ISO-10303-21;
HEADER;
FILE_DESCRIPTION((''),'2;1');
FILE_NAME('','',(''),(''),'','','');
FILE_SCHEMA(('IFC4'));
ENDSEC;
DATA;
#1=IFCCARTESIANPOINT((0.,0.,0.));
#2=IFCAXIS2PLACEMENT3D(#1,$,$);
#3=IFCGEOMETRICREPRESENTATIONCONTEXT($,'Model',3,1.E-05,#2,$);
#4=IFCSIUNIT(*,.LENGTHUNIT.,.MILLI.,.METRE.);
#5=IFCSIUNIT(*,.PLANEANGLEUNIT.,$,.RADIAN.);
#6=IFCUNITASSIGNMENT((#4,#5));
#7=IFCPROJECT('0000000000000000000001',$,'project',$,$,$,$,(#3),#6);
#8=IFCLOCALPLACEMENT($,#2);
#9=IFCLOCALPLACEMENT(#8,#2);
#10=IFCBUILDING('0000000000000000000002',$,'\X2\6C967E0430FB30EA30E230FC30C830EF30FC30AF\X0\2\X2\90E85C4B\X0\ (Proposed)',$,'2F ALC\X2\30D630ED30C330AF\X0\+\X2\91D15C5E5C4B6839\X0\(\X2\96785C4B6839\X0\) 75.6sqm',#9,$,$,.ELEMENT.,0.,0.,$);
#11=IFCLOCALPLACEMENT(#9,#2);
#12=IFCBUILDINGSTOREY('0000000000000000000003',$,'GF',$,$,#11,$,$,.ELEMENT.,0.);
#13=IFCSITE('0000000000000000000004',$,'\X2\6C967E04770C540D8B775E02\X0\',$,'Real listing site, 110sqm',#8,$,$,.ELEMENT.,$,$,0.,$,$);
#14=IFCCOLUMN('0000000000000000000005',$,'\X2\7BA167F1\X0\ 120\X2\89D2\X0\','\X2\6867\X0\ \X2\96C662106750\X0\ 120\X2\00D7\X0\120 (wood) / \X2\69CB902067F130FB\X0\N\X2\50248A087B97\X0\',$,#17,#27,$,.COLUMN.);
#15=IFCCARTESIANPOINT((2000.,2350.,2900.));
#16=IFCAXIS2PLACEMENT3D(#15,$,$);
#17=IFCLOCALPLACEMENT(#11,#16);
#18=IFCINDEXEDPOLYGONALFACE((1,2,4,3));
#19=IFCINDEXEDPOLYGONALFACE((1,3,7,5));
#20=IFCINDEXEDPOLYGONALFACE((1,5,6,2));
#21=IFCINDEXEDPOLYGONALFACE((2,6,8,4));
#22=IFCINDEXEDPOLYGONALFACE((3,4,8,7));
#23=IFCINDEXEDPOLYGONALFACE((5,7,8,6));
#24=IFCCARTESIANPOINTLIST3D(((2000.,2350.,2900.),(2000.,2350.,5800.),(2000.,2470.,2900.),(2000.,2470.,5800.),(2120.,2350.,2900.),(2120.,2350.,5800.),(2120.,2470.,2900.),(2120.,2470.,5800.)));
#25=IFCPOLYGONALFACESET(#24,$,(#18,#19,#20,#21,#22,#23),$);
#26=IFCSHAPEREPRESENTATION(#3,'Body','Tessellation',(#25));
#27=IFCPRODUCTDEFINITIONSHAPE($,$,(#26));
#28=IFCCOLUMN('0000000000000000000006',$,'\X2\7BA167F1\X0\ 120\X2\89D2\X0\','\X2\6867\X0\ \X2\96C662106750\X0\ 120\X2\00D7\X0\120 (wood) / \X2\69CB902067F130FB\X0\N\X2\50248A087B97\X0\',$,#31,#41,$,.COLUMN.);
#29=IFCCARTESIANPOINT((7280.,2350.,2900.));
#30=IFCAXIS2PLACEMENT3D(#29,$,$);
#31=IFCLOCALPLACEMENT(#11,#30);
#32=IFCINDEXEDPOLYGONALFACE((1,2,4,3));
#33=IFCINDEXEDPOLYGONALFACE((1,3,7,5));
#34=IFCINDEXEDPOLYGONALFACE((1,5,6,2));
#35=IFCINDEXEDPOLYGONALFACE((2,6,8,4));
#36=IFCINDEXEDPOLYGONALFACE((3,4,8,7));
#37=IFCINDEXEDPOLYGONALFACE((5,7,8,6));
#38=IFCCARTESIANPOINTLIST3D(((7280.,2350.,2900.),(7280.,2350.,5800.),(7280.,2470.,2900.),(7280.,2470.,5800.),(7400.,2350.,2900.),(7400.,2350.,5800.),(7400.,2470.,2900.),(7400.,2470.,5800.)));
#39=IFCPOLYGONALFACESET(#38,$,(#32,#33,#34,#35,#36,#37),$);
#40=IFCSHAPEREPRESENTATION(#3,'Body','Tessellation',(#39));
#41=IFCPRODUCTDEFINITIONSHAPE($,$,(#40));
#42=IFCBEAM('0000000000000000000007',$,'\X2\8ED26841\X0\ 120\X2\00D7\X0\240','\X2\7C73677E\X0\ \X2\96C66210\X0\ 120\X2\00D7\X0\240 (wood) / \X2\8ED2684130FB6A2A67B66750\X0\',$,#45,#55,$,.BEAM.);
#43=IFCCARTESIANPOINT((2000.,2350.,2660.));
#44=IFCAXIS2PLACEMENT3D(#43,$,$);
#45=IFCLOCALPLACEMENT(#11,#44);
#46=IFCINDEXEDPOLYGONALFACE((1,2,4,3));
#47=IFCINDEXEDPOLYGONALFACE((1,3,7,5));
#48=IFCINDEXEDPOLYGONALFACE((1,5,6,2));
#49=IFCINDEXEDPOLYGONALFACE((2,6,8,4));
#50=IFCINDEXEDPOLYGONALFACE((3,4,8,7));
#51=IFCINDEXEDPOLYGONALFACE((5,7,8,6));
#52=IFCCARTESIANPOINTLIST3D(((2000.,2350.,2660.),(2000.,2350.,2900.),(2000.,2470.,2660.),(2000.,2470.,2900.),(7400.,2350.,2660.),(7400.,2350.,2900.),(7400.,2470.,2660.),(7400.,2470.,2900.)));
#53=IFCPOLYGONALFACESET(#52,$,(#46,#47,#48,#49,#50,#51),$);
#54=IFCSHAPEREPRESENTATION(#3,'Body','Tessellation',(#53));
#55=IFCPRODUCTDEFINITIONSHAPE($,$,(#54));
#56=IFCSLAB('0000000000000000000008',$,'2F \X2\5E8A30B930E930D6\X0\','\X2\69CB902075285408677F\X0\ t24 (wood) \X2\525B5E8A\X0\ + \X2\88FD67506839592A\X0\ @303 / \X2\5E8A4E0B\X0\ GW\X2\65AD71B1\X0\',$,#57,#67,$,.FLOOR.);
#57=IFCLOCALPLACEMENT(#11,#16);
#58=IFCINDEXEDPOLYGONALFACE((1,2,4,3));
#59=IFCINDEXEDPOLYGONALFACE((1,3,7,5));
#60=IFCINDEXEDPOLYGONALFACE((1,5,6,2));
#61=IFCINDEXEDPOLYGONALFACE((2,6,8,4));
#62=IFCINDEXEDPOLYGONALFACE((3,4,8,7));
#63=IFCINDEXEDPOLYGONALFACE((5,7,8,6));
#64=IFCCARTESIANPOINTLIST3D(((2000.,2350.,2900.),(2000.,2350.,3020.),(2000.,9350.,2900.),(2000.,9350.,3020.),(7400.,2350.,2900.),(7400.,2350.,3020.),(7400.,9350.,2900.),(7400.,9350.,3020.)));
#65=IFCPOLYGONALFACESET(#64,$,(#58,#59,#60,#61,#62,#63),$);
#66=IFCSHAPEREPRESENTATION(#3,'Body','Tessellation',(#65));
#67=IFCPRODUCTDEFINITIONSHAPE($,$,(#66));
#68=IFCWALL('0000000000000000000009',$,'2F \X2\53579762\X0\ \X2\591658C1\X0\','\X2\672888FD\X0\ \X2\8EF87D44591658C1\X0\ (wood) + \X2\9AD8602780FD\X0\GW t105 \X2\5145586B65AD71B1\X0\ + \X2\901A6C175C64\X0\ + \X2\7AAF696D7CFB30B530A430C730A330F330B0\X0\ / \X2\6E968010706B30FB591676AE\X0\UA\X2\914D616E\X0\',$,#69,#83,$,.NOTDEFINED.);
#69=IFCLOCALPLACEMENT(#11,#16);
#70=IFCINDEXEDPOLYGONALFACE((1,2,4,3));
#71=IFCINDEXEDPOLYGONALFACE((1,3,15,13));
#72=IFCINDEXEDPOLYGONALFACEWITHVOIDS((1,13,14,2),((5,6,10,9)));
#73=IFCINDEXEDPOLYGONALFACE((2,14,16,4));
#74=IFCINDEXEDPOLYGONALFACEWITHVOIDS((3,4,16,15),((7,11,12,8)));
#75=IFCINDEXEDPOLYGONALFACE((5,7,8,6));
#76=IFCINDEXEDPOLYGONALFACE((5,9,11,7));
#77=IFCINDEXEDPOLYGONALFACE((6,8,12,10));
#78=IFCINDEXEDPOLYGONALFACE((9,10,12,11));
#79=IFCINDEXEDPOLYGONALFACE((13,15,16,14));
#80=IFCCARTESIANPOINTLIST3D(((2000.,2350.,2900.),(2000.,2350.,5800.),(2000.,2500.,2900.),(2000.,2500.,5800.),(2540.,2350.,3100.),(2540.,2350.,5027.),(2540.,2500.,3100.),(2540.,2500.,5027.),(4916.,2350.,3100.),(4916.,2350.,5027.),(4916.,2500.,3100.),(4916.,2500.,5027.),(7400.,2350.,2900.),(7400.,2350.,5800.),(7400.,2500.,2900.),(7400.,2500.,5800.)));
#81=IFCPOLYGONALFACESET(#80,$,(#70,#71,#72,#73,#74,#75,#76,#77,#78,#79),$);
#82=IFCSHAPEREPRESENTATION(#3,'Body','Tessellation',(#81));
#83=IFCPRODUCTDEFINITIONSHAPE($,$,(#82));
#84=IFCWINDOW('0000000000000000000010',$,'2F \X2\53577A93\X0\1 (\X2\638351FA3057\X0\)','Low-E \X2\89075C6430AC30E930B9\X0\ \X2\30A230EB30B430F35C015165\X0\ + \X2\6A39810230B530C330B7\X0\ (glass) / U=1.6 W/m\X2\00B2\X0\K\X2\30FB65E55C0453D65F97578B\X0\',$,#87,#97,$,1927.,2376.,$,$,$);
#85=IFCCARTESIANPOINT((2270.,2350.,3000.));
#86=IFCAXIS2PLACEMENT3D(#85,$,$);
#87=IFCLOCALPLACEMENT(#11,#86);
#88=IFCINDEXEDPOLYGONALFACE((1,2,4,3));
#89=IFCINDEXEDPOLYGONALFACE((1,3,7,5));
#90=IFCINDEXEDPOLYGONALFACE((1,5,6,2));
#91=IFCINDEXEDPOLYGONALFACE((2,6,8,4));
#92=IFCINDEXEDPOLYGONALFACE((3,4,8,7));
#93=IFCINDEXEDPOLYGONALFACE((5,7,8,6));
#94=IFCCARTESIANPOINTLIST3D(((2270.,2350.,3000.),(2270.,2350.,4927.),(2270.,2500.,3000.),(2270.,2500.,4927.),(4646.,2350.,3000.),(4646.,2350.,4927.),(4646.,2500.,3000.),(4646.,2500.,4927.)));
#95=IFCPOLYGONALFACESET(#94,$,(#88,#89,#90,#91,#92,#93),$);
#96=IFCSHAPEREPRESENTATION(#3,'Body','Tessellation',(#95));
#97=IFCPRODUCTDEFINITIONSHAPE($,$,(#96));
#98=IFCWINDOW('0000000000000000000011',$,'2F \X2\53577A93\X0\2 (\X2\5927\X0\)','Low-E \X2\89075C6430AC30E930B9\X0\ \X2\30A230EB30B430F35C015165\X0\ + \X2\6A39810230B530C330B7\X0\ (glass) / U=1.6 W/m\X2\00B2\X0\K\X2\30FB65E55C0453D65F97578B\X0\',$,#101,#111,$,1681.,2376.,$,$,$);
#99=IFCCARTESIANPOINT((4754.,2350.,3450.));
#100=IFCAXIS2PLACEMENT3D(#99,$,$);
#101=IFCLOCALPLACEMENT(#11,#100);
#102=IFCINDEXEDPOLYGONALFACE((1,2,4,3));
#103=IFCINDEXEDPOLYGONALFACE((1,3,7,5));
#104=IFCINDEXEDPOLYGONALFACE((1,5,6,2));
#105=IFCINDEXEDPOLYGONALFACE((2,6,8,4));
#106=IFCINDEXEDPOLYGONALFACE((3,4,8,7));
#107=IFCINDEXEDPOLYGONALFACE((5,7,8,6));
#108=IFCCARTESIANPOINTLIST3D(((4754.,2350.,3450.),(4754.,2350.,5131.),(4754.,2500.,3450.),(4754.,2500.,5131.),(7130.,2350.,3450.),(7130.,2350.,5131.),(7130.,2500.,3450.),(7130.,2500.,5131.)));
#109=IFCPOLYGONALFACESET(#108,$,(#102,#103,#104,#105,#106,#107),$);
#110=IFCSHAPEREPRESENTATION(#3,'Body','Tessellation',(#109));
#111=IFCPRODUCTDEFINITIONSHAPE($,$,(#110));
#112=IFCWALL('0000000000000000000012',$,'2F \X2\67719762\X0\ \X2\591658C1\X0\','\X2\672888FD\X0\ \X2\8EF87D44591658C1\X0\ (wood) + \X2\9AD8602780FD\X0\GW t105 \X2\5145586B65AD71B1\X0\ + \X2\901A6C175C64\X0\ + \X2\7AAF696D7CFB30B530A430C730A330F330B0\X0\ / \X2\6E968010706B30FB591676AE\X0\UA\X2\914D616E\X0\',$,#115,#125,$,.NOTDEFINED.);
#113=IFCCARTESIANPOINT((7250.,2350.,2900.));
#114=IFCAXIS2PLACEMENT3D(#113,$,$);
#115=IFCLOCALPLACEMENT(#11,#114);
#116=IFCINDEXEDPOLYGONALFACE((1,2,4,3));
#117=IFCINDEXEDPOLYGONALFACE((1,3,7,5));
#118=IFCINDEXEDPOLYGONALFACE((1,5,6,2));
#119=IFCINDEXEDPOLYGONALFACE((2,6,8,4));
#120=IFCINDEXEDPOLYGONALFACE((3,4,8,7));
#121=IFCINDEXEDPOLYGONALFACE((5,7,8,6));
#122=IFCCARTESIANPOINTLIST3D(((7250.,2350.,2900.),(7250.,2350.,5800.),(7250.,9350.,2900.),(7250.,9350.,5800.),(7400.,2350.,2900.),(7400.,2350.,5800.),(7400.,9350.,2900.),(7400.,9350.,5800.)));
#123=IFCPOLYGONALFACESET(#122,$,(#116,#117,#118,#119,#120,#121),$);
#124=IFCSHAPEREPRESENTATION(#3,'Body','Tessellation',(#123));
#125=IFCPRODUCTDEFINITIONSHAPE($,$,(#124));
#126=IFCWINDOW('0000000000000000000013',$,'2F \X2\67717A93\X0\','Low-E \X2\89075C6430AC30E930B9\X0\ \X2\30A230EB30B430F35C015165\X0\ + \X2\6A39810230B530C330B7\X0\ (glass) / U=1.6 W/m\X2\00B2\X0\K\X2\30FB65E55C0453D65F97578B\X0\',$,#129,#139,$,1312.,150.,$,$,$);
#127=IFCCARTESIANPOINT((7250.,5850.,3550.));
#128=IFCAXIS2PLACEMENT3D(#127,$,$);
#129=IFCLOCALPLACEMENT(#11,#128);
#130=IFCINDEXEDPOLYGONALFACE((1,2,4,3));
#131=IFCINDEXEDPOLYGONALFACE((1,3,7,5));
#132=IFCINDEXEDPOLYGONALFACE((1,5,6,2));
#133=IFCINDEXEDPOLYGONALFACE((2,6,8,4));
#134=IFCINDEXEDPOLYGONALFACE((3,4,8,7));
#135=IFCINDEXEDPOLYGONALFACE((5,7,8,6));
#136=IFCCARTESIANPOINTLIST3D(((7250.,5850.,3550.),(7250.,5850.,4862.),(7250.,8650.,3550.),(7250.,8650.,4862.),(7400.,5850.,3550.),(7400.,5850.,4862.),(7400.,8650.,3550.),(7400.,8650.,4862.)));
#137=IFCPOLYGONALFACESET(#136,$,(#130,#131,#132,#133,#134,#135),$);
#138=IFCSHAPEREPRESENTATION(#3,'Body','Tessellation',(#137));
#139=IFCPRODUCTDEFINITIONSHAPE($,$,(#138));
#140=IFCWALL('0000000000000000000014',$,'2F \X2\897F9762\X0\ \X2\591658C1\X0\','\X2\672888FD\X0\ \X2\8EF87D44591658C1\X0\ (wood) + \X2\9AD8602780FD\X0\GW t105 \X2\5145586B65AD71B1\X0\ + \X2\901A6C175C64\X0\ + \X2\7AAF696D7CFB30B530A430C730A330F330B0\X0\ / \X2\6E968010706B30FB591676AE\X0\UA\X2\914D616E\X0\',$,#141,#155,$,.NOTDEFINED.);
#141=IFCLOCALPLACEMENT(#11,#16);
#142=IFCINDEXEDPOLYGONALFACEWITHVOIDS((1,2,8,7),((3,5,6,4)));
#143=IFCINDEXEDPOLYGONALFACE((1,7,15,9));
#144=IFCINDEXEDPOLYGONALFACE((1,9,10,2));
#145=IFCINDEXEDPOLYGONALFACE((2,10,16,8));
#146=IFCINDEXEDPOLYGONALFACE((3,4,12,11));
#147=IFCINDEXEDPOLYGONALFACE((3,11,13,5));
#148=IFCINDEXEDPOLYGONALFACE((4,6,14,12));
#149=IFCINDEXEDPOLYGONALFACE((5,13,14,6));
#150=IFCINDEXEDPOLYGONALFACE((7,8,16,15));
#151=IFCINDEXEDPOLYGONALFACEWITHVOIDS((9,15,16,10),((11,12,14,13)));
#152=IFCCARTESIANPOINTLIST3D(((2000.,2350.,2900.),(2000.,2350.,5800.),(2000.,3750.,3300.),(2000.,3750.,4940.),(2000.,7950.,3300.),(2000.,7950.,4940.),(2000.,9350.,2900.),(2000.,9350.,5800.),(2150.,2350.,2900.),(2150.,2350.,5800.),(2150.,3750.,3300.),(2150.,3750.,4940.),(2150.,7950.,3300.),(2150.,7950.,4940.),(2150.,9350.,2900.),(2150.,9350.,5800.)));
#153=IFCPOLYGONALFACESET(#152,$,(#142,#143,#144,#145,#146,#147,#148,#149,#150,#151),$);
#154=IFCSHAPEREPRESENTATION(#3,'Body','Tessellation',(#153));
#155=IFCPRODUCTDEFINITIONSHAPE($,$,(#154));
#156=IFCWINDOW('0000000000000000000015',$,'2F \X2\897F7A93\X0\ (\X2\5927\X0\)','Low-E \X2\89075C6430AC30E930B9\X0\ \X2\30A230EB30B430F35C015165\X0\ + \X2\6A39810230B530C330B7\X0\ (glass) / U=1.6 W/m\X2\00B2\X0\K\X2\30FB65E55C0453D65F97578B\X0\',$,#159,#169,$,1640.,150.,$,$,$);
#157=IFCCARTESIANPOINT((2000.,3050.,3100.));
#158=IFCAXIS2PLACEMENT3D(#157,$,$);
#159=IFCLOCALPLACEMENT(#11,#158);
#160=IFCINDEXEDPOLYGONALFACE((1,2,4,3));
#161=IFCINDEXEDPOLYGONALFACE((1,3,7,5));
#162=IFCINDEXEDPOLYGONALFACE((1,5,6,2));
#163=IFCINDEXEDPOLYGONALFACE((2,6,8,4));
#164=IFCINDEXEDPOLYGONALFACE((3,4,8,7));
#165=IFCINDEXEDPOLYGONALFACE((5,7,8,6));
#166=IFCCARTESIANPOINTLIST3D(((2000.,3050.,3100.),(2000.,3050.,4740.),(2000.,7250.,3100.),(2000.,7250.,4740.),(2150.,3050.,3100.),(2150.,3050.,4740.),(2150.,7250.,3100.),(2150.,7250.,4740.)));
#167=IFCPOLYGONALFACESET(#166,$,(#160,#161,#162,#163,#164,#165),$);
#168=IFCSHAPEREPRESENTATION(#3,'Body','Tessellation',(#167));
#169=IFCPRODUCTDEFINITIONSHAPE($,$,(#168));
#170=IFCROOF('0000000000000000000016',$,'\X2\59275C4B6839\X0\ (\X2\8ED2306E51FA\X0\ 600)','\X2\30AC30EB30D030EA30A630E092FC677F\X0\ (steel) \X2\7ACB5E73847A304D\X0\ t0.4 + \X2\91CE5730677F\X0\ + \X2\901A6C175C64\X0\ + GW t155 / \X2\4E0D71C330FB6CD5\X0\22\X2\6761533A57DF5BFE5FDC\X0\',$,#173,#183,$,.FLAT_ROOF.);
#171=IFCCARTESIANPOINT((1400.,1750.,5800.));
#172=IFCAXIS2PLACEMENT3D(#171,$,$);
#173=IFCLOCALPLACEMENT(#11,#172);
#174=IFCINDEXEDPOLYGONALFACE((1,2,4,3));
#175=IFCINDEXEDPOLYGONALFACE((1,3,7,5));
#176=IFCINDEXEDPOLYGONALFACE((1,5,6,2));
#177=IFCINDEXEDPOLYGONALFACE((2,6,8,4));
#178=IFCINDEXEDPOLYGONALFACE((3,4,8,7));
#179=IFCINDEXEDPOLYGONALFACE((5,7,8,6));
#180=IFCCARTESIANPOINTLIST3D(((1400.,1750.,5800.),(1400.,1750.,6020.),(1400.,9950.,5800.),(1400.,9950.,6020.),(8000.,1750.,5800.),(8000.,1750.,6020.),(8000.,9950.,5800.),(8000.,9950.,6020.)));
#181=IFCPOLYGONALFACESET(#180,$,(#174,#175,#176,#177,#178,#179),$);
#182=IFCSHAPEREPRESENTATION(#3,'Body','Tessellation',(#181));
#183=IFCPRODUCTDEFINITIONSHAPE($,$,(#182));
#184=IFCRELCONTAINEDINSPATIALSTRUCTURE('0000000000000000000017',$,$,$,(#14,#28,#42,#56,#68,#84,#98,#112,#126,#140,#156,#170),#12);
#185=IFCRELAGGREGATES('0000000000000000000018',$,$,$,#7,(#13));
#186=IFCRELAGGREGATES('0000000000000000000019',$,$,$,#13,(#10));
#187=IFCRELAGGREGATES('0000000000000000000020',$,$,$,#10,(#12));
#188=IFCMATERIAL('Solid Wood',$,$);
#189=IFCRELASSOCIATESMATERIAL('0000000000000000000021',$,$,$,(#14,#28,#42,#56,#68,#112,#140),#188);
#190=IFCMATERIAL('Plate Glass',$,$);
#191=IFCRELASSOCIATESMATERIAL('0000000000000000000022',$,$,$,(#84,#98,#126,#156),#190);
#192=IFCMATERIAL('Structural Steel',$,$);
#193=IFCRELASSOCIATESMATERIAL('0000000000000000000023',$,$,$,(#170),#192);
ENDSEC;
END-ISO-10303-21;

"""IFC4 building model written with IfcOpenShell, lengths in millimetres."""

from ifc_helpers import new_model, si_unit, frame, frame_2d, origin, place, context, project, spatial, rectangle, extrude, material, element, fill, save


model = new_model("IFC4")

# Units and contexts
model_context = context("Model", 3, precision=1e-05, world=origin())
ifc_project = project(units=[si_unit("LENGTHUNIT", "METRE", prefix="MILLI"), si_unit("PLANEANGLEUNIT", "RADIAN")], contexts=[model_context])

# Site, building, storey
site_placement = place(None, origin())
site = spatial("IfcSite", under=ifc_project, at=site_placement, Name="沖縄県名護市", ObjectType="Real listing site, 110sqm", CompositionType="ELEMENT", RefElevation=0.0)
building_placement = place(site_placement, origin())
building = spatial("IfcBuilding", under=site, at=building_placement, Name="沖縄・リモートワーク2部屋 (Proposed)", ObjectType="2F ALCブロック+金属屋根(陸屋根) 75.6sqm", CompositionType="ELEMENT", ElevationOfRefHeight=0.0, ElevationOfTerrain=0.0)
storey_placement = place(building_placement, origin())
storey = spatial("IfcBuildingStorey", under=building, at=storey_placement, Name="GF", CompositionType="ELEMENT", Elevation=0.0)

# Columns
ifc_material_1 = material(Name="Solid Wood")
column_1_placement = place(storey_placement, frame((2000.0, 2350.0, 2900.0)))
element("IfcColumn", 1, at=column_1_placement, inside=storey, material=ifc_material_1, Name="管柱 120角", Description="桧 集成材 120×120 (wood) / 構造柱・N値計算", PredefinedType="COLUMN", context=model_context, shape_type="SweptSolid", body=[
    extrude(rectangle(XDim=120.0, YDim=120.0, at=frame_2d((60.0, 60.0))), frame((2000.0, 2350.0, 2900.0)), (0.0, 0.0, 1.0), 2900.0),
])
column_2_placement = place(storey_placement, frame((7280.0, 2350.0, 2900.0)))
element("IfcColumn", 2, at=column_2_placement, inside=storey, material=ifc_material_1, Name="管柱 120角", Description="桧 集成材 120×120 (wood) / 構造柱・N値計算", PredefinedType="COLUMN", context=model_context, shape_type="SweptSolid", body=[
    extrude(rectangle(XDim=120.0, YDim=120.0, at=frame_2d((60.0, 60.0))), frame((7280.0, 2350.0, 2900.0)), (0.0, 0.0, 1.0), 2900.0),
])

# Beam
beam_1_placement = place(storey_placement, frame((2000.0, 2350.0, 2660.0)))
element("IfcBeam", 3, at=beam_1_placement, inside=storey, material=ifc_material_1, Name="軒桁 120×240", Description="米松 集成 120×240 (wood) / 軒桁・横架材", PredefinedType="BEAM", context=model_context, shape_type="SweptSolid", body=[
    extrude(rectangle(XDim=5400.0, YDim=120.0, at=frame_2d((2700.0, 60.0))), frame((2000.0, 2350.0, 2660.0)), (0.0, 0.0, 1.0), 240.0),
])

# Slab
slab_placement = place(storey_placement, frame((2000.0, 2350.0, 2900.0)))
element("IfcSlab", 4, at=slab_placement, inside=storey, material=ifc_material_1, Name="2F 床スラブ", Description="構造用合板 t24 (wood) 剛床 + 製材根太 @303 / 床下 GW断熱", PredefinedType="FLOOR", context=model_context, shape_type="SweptSolid", body=[
    extrude(rectangle(XDim=5400.0, YDim=7000.0, at=frame_2d((2700.0, 3500.0))), frame((2000.0, 2350.0, 2900.0)), (0.0, 0.0, 1.0), 120.0),
])

# Wall, openings, windows
wall_1_placement = place(storey_placement, frame((2000.0, 2350.0, 2900.0)))
wall_1 = element("IfcWall", 5, at=wall_1_placement, inside=storey, material=ifc_material_1, Name="2F 南面 外壁", Description="木製 軸組外壁 (wood) + 高性能GW t105 充填断熱 + 通気層 + 窯業系サイディング / 準耐火・外皮UA配慮", PredefinedType="NOTDEFINED", context=model_context, shape_type="SweptSolid", body=[
    extrude(rectangle(XDim=5400.0, YDim=150.0, at=frame_2d((2700.0, 75.0))), frame((2000.0, 2350.0, 2900.0)), (0.0, 0.0, 1.0), 2900.0),
])
opening_1_placement = place(storey_placement, frame((2270.0, 2350.0, 3000.0)))
opening_1 = element("IfcOpeningElement", 6, at=opening_1_placement, cuts=wall_1, PredefinedType="NOTDEFINED", context=model_context, shape_type="SweptSolid", body=[
    extrude(rectangle(XDim=2376.0, YDim=150.0, at=frame_2d((1188.0, 75.0))), frame((2270.0, 2350.0, 3000.0)), (0.0, 0.0, 1.0), 1927.0),
])
opening_2_placement = place(storey_placement, frame((4754.0, 2350.0, 3450.0)))
opening_2 = element("IfcOpeningElement", 7, at=opening_2_placement, cuts=wall_1, PredefinedType="NOTDEFINED", context=model_context, shape_type="SweptSolid", body=[
    extrude(rectangle(XDim=2376.0, YDim=150.0, at=frame_2d((1188.0, 75.0))), frame((4754.0, 2350.0, 3450.0)), (0.0, 0.0, 1.0), 1681.0),
])
ifc_material_2 = material(Name="Plate Glass")
window_1_placement = place(storey_placement, frame((2270.0, 2350.0, 3000.0)))
window_1 = element("IfcWindow", 8, at=window_1_placement, inside=storey, material=ifc_material_2, Name="2F 南窓1 (掃出し)", Description="Low-E 複層ガラス アルゴン封入 + 樹脂サッシ (glass) / U=1.6 W/m²K・日射取得型", OverallHeight=1927.0, OverallWidth=2376.0, context=model_context, shape_type="SweptSolid", body=[
    extrude(rectangle(XDim=2376.0, YDim=150.0, at=frame_2d((1188.0, 75.0))), frame((2270.0, 2350.0, 3000.0)), (0.0, 0.0, 1.0), 1927.0),
])
fill(opening_1, window_1)
window_2_placement = place(storey_placement, frame((4754.0, 2350.0, 3450.0)))
window_2 = element("IfcWindow", 9, at=window_2_placement, inside=storey, material=ifc_material_2, Name="2F 南窓2 (大)", Description="Low-E 複層ガラス アルゴン封入 + 樹脂サッシ (glass) / U=1.6 W/m²K・日射取得型", OverallHeight=1681.0, OverallWidth=2376.0, context=model_context, shape_type="SweptSolid", body=[
    extrude(rectangle(XDim=2376.0, YDim=150.0, at=frame_2d((1188.0, 75.0))), frame((4754.0, 2350.0, 3450.0)), (0.0, 0.0, 1.0), 1681.0),
])
fill(opening_2, window_2)

# Walls, openings, windows
wall_2_placement = place(storey_placement, frame((7250.0, 2350.0, 2900.0)))
wall_2 = element("IfcWall", 10, at=wall_2_placement, inside=storey, material=ifc_material_1, Name="2F 東面 外壁", Description="木製 軸組外壁 (wood) + 高性能GW t105 充填断熱 + 通気層 + 窯業系サイディング / 準耐火・外皮UA配慮", PredefinedType="NOTDEFINED", context=model_context, shape_type="SweptSolid", body=[
    extrude(rectangle(XDim=150.0, YDim=7000.0, at=frame_2d((75.0, 3500.0))), frame((7250.0, 2350.0, 2900.0)), (0.0, 0.0, 1.0), 2900.0),
])
opening_3_placement = place(storey_placement, frame((7250.0, 5850.0, 3550.0)))
opening_3 = element("IfcOpeningElement", 11, at=opening_3_placement, cuts=wall_2, PredefinedType="NOTDEFINED", context=model_context, shape_type="SweptSolid", body=[
    extrude(rectangle(XDim=150.0, YDim=2800.0, at=frame_2d((75.0, 1400.0))), frame((7250.0, 5850.0, 3550.0)), (0.0, 0.0, 1.0), 1312.0),
])
window_3_placement = place(storey_placement, frame((7250.0, 5850.0, 3550.0)))
window_3 = element("IfcWindow", 12, at=window_3_placement, inside=storey, material=ifc_material_2, Name="2F 東窓", Description="Low-E 複層ガラス アルゴン封入 + 樹脂サッシ (glass) / U=1.6 W/m²K・日射取得型", OverallHeight=1312.0, OverallWidth=150.0, context=model_context, shape_type="SweptSolid", body=[
    extrude(rectangle(XDim=150.0, YDim=2800.0, at=frame_2d((75.0, 1400.0))), frame((7250.0, 5850.0, 3550.0)), (0.0, 0.0, 1.0), 1312.0),
])
fill(opening_3, window_3)
wall_3_placement = place(storey_placement, frame((2000.0, 2350.0, 2900.0)))
wall_3 = element("IfcWall", 13, at=wall_3_placement, inside=storey, material=ifc_material_1, Name="2F 西面 外壁", Description="木製 軸組外壁 (wood) + 高性能GW t105 充填断熱 + 通気層 + 窯業系サイディング / 準耐火・外皮UA配慮", PredefinedType="NOTDEFINED", context=model_context, shape_type="SweptSolid", body=[
    extrude(rectangle(XDim=150.0, YDim=7000.0, at=frame_2d((75.0, 3500.0))), frame((2000.0, 2350.0, 2900.0)), (0.0, 0.0, 1.0), 2900.0),
])
opening_4_placement = place(storey_placement, frame((2000.0, 3050.0, 3100.0)))
opening_4 = element("IfcOpeningElement", 14, at=opening_4_placement, cuts=wall_3, PredefinedType="NOTDEFINED", context=model_context, shape_type="SweptSolid", body=[
    extrude(rectangle(XDim=150.0, YDim=4200.0, at=frame_2d((75.0, 2100.0))), frame((2000.0, 3050.0, 3100.0)), (0.0, 0.0, 1.0), 1640.0),
])
window_4_placement = place(storey_placement, frame((2000.0, 3050.0, 3100.0)))
window_4 = element("IfcWindow", 15, at=window_4_placement, inside=storey, material=ifc_material_2, Name="2F 西窓 (大)", Description="Low-E 複層ガラス アルゴン封入 + 樹脂サッシ (glass) / U=1.6 W/m²K・日射取得型", OverallHeight=1640.0, OverallWidth=150.0, context=model_context, shape_type="SweptSolid", body=[
    extrude(rectangle(XDim=150.0, YDim=4200.0, at=frame_2d((75.0, 2100.0))), frame((2000.0, 3050.0, 3100.0)), (0.0, 0.0, 1.0), 1640.0),
])
fill(opening_4, window_4)

# Roof
ifc_material_3 = material(Name="Structural Steel")
roof_placement = place(storey_placement, frame((1400.0, 1750.0, 5800.0)))
element("IfcRoof", 16, at=roof_placement, inside=storey, material=ifc_material_3, Name="大屋根 (軒の出 600)", Description="ガルバリウム鋼板 (steel) 立平葺き t0.4 + 野地板 + 通気層 + GW t155 / 不燃・法22条区域対応", PredefinedType="FLAT_ROOF", context=model_context, shape_type="SweptSolid", body=[
    extrude(rectangle(XDim=6600.0, YDim=8200.0, at=frame_2d((3300.0, 4100.0))), frame((1400.0, 1750.0, 5800.0)), (0.0, 0.0, 1.0), 220.0),
])

save(model, "model.ifc")
